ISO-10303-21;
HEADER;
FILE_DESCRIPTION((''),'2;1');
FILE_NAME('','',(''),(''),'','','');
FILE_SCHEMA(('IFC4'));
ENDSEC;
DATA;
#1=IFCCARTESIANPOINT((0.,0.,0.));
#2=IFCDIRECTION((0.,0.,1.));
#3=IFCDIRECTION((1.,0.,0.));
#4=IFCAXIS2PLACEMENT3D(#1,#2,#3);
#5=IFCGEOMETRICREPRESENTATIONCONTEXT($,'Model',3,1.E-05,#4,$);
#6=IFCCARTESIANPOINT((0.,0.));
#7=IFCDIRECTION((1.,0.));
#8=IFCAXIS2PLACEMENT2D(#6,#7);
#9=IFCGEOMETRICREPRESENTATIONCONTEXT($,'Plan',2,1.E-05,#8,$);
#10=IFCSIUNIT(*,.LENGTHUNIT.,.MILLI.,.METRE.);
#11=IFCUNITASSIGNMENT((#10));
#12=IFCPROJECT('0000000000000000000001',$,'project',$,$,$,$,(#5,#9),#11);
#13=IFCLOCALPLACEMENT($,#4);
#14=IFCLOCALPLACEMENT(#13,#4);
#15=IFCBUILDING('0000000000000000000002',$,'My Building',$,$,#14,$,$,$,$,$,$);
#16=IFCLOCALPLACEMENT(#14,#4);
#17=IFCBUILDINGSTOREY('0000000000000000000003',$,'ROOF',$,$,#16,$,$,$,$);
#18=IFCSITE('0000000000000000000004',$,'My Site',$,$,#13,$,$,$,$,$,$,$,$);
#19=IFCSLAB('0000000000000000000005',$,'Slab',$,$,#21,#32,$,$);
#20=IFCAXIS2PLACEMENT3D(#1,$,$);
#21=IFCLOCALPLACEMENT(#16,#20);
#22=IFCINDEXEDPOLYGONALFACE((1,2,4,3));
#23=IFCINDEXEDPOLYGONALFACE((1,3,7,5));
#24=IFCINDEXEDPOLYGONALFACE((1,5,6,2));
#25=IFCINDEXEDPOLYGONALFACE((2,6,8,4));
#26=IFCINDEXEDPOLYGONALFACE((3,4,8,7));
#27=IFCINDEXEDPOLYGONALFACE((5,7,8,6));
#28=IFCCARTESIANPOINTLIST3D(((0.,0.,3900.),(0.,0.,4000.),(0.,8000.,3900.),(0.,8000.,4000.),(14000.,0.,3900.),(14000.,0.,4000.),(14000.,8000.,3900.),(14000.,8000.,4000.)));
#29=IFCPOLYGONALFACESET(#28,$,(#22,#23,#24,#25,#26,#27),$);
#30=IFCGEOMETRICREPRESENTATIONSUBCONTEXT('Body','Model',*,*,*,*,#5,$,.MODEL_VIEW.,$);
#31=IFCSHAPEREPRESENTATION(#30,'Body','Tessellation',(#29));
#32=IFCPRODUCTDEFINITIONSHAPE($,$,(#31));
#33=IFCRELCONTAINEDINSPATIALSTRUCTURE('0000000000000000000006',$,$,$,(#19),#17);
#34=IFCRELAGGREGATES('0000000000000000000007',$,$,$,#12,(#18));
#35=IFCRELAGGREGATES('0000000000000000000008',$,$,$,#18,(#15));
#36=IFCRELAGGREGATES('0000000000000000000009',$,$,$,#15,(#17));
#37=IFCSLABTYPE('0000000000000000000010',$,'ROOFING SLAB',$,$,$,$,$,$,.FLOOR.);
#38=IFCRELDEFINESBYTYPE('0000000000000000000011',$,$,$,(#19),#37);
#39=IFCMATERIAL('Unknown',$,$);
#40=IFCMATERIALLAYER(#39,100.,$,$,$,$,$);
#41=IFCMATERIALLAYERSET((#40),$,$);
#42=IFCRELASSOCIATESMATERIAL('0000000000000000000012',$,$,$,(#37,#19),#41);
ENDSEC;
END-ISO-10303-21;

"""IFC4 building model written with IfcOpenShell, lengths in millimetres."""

from ifc_helpers import new_model, si_unit, frame, origin_with_axes, origin_2d_with_axis, place, context, subcontext, project, spatial, indexed_curve, outline, extrude, material, layer, layer_set, layer_usage, type_object, element, save


model = new_model("IFC4")

# Units and contexts
model_context = context("Model", 3, precision=1e-05, world=origin_with_axes())
plan_context = context("Plan", 2, precision=1e-05, world=origin_2d_with_axis())
body_context = subcontext(model_context, "Body", "Model", "MODEL_VIEW")
ifc_project = project(units=[si_unit("LENGTHUNIT", "METRE", prefix="MILLI")], contexts=[model_context, plan_context])

# Site, building, storey
site_placement = place(None, origin_with_axes())
site = spatial("IfcSite", under=ifc_project, at=site_placement, Name="My Site")
building_placement = place(site_placement, origin_with_axes())
building = spatial("IfcBuilding", under=site, at=building_placement, Name="My Building")
storey_placement = place(building_placement, origin_with_axes())
storey = spatial("IfcBuildingStorey", under=building, at=storey_placement, Name="ROOF")

# Slab
ifc_material = material(Name="Unknown")
ifc_layer = layer(ifc_material, 100.0)
ifc_layer_set = layer_set([ifc_layer])
ifc_layer_usage = layer_usage(ifc_layer_set, "AXIS3", "POSITIVE", -100.0)
slab_type = type_object("IfcSlabType", Name="ROOFING SLAB", PredefinedType="FLOOR", material=ifc_layer_set)
slab_placement = place(storey_placement, frame((0.0, 8000.0, 4000.0), z_axis=(0.0, 0.0, 1.0), x_axis=(1.0, 0.0, 0.0)))
element("IfcSlab", 1, at=slab_placement, inside=storey, type_object=slab_type, material=ifc_layer_usage, Name="Slab", context=body_context, shape_type="SweptSolid", body=[
    extrude(outline(indexed_curve([(0.0, 0.0), (14000.0, 0.0), (14000.0, -8000.0), (0.0, -8000.0), (0.0, 0.0)])), frame((0.0, 0.0, -100.0), z_axis=(0.0, 0.0, 1.0), x_axis=(1.0, 0.0, 0.0)), (0.0, 0.0, 1.0), 100.0),
])

save(model, "model.ifc")
